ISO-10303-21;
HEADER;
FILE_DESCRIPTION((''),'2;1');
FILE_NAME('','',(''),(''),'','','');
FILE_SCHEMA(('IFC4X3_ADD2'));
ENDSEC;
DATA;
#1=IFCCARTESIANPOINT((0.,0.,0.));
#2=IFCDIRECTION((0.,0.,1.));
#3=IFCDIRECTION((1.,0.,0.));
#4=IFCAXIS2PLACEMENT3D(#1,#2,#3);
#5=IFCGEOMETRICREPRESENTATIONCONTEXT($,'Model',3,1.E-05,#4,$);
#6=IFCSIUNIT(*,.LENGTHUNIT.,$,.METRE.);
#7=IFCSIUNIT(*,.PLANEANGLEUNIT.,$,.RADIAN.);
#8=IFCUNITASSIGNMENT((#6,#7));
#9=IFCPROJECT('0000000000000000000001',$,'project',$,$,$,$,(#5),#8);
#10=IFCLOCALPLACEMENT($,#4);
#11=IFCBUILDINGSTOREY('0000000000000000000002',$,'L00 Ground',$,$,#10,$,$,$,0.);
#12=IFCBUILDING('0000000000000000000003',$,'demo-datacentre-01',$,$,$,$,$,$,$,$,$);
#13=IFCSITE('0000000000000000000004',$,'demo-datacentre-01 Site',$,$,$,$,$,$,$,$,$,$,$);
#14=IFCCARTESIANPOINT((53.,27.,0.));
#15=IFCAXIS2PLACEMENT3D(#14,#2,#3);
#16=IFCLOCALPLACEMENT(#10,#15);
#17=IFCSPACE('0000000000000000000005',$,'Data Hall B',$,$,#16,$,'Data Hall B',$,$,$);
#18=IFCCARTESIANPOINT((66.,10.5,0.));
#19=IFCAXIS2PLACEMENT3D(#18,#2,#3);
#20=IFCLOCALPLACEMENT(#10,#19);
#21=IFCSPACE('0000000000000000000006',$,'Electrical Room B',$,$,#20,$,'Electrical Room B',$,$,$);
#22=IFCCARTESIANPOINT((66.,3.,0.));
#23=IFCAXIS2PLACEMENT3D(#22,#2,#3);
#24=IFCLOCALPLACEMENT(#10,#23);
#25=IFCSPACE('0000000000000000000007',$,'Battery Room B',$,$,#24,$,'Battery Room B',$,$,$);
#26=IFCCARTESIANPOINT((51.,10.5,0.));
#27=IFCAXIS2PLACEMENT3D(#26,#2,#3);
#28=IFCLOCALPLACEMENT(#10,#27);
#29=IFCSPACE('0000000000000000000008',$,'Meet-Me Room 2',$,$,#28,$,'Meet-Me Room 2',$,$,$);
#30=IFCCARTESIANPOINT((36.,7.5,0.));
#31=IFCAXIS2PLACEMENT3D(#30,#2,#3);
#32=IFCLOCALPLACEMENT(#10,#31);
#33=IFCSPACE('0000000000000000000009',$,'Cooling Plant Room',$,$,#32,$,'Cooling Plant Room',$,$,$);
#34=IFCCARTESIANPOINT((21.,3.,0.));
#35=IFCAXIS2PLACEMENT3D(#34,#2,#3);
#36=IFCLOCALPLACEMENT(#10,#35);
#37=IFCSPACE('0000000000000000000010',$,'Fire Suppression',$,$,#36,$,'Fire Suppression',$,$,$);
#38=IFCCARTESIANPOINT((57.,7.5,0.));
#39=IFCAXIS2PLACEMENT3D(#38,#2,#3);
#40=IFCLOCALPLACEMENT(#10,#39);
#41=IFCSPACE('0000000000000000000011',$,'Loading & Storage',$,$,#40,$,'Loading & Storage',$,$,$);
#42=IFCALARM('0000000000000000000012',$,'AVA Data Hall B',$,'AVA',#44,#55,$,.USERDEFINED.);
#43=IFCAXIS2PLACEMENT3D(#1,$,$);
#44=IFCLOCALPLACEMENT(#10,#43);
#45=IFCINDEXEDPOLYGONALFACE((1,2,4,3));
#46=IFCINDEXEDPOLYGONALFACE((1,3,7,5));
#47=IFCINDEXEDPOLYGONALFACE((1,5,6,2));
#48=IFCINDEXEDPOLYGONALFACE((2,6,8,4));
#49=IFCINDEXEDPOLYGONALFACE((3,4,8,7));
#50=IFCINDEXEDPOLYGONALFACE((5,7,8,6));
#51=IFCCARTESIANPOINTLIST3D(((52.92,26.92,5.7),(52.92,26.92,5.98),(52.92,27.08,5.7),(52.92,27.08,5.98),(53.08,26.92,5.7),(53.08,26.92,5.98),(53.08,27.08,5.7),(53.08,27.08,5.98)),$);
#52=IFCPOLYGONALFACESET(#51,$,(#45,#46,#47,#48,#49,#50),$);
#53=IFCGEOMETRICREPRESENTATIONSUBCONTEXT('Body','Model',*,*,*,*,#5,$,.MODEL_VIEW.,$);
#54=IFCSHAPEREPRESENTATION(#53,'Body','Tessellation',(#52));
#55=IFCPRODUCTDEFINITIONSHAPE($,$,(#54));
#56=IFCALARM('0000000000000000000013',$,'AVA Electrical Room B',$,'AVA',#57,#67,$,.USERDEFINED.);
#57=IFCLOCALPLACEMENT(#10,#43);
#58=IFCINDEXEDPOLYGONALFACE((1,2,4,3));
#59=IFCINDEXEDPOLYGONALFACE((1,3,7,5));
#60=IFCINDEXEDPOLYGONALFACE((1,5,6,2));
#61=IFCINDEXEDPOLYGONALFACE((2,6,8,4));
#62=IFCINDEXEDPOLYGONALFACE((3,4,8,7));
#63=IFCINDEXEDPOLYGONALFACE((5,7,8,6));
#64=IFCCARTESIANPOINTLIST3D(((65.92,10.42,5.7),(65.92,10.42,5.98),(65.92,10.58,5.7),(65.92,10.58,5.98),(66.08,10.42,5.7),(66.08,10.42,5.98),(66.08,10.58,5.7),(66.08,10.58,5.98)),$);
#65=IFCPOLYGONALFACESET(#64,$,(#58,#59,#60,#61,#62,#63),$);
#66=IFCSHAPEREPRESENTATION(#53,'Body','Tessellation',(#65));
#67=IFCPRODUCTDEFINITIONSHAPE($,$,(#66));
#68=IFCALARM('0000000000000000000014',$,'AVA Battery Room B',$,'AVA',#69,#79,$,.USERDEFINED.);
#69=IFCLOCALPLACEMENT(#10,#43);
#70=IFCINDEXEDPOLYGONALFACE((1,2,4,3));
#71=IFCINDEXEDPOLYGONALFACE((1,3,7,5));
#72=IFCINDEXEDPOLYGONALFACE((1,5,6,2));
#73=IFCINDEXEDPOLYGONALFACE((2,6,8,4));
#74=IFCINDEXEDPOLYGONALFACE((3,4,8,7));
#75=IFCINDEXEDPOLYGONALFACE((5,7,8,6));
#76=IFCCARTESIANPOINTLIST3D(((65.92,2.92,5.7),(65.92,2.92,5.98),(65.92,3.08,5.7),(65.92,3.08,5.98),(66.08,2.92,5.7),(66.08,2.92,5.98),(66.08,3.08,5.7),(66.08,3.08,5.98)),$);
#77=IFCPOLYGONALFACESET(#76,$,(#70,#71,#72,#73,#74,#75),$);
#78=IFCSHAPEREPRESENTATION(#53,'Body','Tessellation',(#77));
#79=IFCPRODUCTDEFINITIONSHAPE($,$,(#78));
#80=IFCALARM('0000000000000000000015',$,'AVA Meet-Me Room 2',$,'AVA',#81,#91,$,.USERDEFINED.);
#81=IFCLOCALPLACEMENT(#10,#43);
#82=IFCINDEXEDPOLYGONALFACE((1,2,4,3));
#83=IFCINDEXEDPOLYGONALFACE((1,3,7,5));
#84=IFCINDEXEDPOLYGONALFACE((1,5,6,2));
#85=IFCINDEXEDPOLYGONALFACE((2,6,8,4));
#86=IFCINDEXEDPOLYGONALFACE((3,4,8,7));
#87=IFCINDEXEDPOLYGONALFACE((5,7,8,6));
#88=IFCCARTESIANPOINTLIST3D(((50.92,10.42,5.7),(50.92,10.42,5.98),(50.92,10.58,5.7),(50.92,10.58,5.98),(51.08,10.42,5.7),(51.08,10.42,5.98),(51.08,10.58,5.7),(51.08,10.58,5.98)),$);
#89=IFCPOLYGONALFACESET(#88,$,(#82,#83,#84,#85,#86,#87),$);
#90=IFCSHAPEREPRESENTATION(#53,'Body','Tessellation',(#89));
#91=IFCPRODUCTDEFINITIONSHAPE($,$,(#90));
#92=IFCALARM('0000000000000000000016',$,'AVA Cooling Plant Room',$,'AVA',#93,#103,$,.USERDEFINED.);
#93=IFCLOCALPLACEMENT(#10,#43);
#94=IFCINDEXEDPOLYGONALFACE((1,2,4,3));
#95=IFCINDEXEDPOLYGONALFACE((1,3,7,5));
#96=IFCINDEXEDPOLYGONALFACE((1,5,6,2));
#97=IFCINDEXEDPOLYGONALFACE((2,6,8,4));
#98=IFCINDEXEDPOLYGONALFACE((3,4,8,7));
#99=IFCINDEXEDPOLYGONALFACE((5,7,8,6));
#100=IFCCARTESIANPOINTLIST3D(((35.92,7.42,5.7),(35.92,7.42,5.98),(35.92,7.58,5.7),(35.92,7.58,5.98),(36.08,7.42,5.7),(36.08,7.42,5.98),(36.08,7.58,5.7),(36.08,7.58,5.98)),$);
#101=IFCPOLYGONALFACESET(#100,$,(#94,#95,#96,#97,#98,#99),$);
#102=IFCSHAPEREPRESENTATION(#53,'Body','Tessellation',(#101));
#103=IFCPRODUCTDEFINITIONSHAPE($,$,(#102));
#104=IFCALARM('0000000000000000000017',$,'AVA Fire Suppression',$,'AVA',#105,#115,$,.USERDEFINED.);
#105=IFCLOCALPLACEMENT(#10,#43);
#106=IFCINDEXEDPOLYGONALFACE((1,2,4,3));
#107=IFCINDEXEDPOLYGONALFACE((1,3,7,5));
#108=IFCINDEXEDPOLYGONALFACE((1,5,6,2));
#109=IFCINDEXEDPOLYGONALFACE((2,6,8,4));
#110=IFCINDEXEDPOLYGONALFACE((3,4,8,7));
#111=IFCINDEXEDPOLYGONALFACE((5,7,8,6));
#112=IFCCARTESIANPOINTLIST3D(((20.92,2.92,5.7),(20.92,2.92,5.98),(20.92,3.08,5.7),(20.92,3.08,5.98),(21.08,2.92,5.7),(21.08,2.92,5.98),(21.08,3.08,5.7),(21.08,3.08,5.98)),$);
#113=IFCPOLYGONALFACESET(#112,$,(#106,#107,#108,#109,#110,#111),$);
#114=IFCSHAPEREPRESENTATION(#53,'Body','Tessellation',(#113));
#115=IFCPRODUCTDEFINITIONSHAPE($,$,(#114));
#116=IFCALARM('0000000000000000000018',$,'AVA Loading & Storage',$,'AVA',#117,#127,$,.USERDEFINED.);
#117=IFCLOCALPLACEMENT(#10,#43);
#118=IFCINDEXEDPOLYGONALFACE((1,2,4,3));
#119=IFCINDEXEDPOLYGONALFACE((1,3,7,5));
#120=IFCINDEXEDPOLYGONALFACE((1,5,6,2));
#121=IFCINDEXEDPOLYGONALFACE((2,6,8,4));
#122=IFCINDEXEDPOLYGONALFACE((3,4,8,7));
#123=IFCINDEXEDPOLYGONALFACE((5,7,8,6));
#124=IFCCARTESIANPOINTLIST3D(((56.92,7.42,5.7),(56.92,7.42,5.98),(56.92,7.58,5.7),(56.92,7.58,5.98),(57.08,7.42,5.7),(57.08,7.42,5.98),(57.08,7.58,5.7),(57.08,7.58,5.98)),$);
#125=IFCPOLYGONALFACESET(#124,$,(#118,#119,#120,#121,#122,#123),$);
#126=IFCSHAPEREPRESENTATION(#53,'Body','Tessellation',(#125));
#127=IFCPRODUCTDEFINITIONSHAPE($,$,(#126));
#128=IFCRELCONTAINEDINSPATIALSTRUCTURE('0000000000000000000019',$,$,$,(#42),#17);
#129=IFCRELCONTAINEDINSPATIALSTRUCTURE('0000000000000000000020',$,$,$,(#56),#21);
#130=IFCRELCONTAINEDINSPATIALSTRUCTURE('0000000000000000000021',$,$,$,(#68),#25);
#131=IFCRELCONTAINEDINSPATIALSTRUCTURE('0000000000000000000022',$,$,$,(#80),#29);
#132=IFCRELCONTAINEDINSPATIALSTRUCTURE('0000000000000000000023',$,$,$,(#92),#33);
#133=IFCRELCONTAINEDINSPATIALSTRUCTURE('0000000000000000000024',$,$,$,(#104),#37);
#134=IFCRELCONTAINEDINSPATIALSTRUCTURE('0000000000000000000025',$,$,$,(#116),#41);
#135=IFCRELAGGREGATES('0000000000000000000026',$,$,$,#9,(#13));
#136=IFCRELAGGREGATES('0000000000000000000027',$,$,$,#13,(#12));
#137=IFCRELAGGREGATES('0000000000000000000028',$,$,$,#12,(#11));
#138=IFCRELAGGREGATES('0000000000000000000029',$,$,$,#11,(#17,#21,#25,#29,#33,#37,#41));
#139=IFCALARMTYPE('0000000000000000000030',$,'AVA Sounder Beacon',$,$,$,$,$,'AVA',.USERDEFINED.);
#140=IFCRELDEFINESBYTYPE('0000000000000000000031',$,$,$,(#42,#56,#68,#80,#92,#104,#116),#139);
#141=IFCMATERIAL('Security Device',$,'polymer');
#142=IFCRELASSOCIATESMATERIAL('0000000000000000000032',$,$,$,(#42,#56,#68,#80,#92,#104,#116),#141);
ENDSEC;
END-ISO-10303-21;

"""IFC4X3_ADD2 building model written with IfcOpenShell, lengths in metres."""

from ifc_helpers import new_model, si_unit, frame, origin_with_axes, place, context, subcontext, project, spatial, rectangle, extrude, material, type_object, element, save


model = new_model("IFC4X3_ADD2")

# Units and contexts
model_context = context("Model", 3, precision=1e-05, world=origin_with_axes())
body_context = subcontext(model_context, "Body", "Model", "MODEL_VIEW")
ifc_project = project(units=[si_unit("LENGTHUNIT", "METRE"), si_unit("PLANEANGLEUNIT", "RADIAN")], contexts=[model_context])

# Site, building, storey, space
site = spatial("IfcSite", under=ifc_project, Name="demo-datacentre-01 Site")
building = spatial("IfcBuilding", under=site, Name="demo-datacentre-01")
storey_placement = place(None, origin_with_axes())
storey = spatial("IfcBuildingStorey", under=building, at=storey_placement, Name="L00 Ground", Elevation=0.0)
space_1_placement = place(storey_placement, frame((53.0, 27.0, 0.0), z_axis=(0.0, 0.0, 1.0), x_axis=(1.0, 0.0, 0.0)))
space_1 = spatial("IfcSpace", under=storey, at=space_1_placement, Name="Data Hall B", LongName="Data Hall B")

# Alarm
ifc_material = material(Name="Security Device", Category="polymer")
alarm_type = type_object("IfcAlarmType", Name="AVA Sounder Beacon", ElementType="AVA", PredefinedType="USERDEFINED")
alarm_1_placement = place(space_1_placement, frame((0.0, 0.0, 5.7), z_axis=(0.0, 0.0, 1.0), x_axis=(1.0, 0.0, 0.0)))
element("IfcAlarm", 1, at=alarm_1_placement, inside=space_1, type_object=alarm_type, material=ifc_material, Name="AVA Data Hall B", ObjectType="AVA", PredefinedType="USERDEFINED", context=body_context, shape_type="SweptSolid", body=[
    extrude(rectangle(XDim=0.16, YDim=0.16), origin_with_axes(), (0.0, 0.0, 1.0), 0.28),
])

# Shared definitions
space_2_placement = place(storey_placement, frame((66.0, 10.5, 0.0), z_axis=(0.0, 0.0, 1.0), x_axis=(1.0, 0.0, 0.0)))
space_2 = spatial("IfcSpace", under=storey, at=space_2_placement, Name="Electrical Room B", LongName="Electrical Room B")

# Alarm
alarm_2_placement = place(space_2_placement, frame((0.0, 0.0, 5.7), z_axis=(0.0, 0.0, 1.0), x_axis=(1.0, 0.0, 0.0)))
element("IfcAlarm", 2, at=alarm_2_placement, inside=space_2, type_object=alarm_type, material=ifc_material, Name="AVA Electrical Room B", ObjectType="AVA", PredefinedType="USERDEFINED", context=body_context, shape_type="SweptSolid", body=[
    extrude(rectangle(XDim=0.16, YDim=0.16), origin_with_axes(), (0.0, 0.0, 1.0), 0.28),
])

# Shared definitions
space_3_placement = place(storey_placement, frame((66.0, 3.0, 0.0), z_axis=(0.0, 0.0, 1.0), x_axis=(1.0, 0.0, 0.0)))
space_3 = spatial("IfcSpace", under=storey, at=space_3_placement, Name="Battery Room B", LongName="Battery Room B")

# Alarm
alarm_3_placement = place(space_3_placement, frame((0.0, 0.0, 5.7), z_axis=(0.0, 0.0, 1.0), x_axis=(1.0, 0.0, 0.0)))
element("IfcAlarm", 3, at=alarm_3_placement, inside=space_3, type_object=alarm_type, material=ifc_material, Name="AVA Battery Room B", ObjectType="AVA", PredefinedType="USERDEFINED", context=body_context, shape_type="SweptSolid", body=[
    extrude(rectangle(XDim=0.16, YDim=0.16), origin_with_axes(), (0.0, 0.0, 1.0), 0.28),
])

# Shared definitions
space_4_placement = place(storey_placement, frame((51.0, 10.5, 0.0), z_axis=(0.0, 0.0, 1.0), x_axis=(1.0, 0.0, 0.0)))
space_4 = spatial("IfcSpace", under=storey, at=space_4_placement, Name="Meet-Me Room 2", LongName="Meet-Me Room 2")

# Alarm
alarm_4_placement = place(space_4_placement, frame((0.0, 0.0, 5.7), z_axis=(0.0, 0.0, 1.0), x_axis=(1.0, 0.0, 0.0)))
element("IfcAlarm", 4, at=alarm_4_placement, inside=space_4, type_object=alarm_type, material=ifc_material, Name="AVA Meet-Me Room 2", ObjectType="AVA", PredefinedType="USERDEFINED", context=body_context, shape_type="SweptSolid", body=[
    extrude(rectangle(XDim=0.16, YDim=0.16), origin_with_axes(), (0.0, 0.0, 1.0), 0.28),
])

# Shared definitions
space_5_placement = place(storey_placement, frame((36.0, 7.5, 0.0), z_axis=(0.0, 0.0, 1.0), x_axis=(1.0, 0.0, 0.0)))
space_5 = spatial("IfcSpace", under=storey, at=space_5_placement, Name="Cooling Plant Room", LongName="Cooling Plant Room")

# Alarm
alarm_5_placement = place(space_5_placement, frame((0.0, 0.0, 5.7), z_axis=(0.0, 0.0, 1.0), x_axis=(1.0, 0.0, 0.0)))
element("IfcAlarm", 5, at=alarm_5_placement, inside=space_5, type_object=alarm_type, material=ifc_material, Name="AVA Cooling Plant Room", ObjectType="AVA", PredefinedType="USERDEFINED", context=body_context, shape_type="SweptSolid", body=[
    extrude(rectangle(XDim=0.16, YDim=0.16), origin_with_axes(), (0.0, 0.0, 1.0), 0.28),
])

# Shared definitions
space_6_placement = place(storey_placement, frame((21.0, 3.0, 0.0), z_axis=(0.0, 0.0, 1.0), x_axis=(1.0, 0.0, 0.0)))
space_6 = spatial("IfcSpace", under=storey, at=space_6_placement, Name="Fire Suppression", LongName="Fire Suppression")

# Alarm
alarm_6_placement = place(space_6_placement, frame((0.0, 0.0, 5.7), z_axis=(0.0, 0.0, 1.0), x_axis=(1.0, 0.0, 0.0)))
element("IfcAlarm", 6, at=alarm_6_placement, inside=space_6, type_object=alarm_type, material=ifc_material, Name="AVA Fire Suppression", ObjectType="AVA", PredefinedType="USERDEFINED", context=body_context, shape_type="SweptSolid", body=[
    extrude(rectangle(XDim=0.16, YDim=0.16), origin_with_axes(), (0.0, 0.0, 1.0), 0.28),
])

# Shared definitions
space_7_placement = place(storey_placement, frame((57.0, 7.5, 0.0), z_axis=(0.0, 0.0, 1.0), x_axis=(1.0, 0.0, 0.0)))
space_7 = spatial("IfcSpace", under=storey, at=space_7_placement, Name="Loading & Storage", LongName="Loading & Storage")

# Alarm
alarm_7_placement = place(space_7_placement, frame((0.0, 0.0, 5.7), z_axis=(0.0, 0.0, 1.0), x_axis=(1.0, 0.0, 0.0)))
element("IfcAlarm", 7, at=alarm_7_placement, inside=space_7, type_object=alarm_type, material=ifc_material, Name="AVA Loading & Storage", ObjectType="AVA", PredefinedType="USERDEFINED", context=body_context, shape_type="SweptSolid", body=[
    extrude(rectangle(XDim=0.16, YDim=0.16), origin_with_axes(), (0.0, 0.0, 1.0), 0.28),
])

save(model, "model.ifc")
